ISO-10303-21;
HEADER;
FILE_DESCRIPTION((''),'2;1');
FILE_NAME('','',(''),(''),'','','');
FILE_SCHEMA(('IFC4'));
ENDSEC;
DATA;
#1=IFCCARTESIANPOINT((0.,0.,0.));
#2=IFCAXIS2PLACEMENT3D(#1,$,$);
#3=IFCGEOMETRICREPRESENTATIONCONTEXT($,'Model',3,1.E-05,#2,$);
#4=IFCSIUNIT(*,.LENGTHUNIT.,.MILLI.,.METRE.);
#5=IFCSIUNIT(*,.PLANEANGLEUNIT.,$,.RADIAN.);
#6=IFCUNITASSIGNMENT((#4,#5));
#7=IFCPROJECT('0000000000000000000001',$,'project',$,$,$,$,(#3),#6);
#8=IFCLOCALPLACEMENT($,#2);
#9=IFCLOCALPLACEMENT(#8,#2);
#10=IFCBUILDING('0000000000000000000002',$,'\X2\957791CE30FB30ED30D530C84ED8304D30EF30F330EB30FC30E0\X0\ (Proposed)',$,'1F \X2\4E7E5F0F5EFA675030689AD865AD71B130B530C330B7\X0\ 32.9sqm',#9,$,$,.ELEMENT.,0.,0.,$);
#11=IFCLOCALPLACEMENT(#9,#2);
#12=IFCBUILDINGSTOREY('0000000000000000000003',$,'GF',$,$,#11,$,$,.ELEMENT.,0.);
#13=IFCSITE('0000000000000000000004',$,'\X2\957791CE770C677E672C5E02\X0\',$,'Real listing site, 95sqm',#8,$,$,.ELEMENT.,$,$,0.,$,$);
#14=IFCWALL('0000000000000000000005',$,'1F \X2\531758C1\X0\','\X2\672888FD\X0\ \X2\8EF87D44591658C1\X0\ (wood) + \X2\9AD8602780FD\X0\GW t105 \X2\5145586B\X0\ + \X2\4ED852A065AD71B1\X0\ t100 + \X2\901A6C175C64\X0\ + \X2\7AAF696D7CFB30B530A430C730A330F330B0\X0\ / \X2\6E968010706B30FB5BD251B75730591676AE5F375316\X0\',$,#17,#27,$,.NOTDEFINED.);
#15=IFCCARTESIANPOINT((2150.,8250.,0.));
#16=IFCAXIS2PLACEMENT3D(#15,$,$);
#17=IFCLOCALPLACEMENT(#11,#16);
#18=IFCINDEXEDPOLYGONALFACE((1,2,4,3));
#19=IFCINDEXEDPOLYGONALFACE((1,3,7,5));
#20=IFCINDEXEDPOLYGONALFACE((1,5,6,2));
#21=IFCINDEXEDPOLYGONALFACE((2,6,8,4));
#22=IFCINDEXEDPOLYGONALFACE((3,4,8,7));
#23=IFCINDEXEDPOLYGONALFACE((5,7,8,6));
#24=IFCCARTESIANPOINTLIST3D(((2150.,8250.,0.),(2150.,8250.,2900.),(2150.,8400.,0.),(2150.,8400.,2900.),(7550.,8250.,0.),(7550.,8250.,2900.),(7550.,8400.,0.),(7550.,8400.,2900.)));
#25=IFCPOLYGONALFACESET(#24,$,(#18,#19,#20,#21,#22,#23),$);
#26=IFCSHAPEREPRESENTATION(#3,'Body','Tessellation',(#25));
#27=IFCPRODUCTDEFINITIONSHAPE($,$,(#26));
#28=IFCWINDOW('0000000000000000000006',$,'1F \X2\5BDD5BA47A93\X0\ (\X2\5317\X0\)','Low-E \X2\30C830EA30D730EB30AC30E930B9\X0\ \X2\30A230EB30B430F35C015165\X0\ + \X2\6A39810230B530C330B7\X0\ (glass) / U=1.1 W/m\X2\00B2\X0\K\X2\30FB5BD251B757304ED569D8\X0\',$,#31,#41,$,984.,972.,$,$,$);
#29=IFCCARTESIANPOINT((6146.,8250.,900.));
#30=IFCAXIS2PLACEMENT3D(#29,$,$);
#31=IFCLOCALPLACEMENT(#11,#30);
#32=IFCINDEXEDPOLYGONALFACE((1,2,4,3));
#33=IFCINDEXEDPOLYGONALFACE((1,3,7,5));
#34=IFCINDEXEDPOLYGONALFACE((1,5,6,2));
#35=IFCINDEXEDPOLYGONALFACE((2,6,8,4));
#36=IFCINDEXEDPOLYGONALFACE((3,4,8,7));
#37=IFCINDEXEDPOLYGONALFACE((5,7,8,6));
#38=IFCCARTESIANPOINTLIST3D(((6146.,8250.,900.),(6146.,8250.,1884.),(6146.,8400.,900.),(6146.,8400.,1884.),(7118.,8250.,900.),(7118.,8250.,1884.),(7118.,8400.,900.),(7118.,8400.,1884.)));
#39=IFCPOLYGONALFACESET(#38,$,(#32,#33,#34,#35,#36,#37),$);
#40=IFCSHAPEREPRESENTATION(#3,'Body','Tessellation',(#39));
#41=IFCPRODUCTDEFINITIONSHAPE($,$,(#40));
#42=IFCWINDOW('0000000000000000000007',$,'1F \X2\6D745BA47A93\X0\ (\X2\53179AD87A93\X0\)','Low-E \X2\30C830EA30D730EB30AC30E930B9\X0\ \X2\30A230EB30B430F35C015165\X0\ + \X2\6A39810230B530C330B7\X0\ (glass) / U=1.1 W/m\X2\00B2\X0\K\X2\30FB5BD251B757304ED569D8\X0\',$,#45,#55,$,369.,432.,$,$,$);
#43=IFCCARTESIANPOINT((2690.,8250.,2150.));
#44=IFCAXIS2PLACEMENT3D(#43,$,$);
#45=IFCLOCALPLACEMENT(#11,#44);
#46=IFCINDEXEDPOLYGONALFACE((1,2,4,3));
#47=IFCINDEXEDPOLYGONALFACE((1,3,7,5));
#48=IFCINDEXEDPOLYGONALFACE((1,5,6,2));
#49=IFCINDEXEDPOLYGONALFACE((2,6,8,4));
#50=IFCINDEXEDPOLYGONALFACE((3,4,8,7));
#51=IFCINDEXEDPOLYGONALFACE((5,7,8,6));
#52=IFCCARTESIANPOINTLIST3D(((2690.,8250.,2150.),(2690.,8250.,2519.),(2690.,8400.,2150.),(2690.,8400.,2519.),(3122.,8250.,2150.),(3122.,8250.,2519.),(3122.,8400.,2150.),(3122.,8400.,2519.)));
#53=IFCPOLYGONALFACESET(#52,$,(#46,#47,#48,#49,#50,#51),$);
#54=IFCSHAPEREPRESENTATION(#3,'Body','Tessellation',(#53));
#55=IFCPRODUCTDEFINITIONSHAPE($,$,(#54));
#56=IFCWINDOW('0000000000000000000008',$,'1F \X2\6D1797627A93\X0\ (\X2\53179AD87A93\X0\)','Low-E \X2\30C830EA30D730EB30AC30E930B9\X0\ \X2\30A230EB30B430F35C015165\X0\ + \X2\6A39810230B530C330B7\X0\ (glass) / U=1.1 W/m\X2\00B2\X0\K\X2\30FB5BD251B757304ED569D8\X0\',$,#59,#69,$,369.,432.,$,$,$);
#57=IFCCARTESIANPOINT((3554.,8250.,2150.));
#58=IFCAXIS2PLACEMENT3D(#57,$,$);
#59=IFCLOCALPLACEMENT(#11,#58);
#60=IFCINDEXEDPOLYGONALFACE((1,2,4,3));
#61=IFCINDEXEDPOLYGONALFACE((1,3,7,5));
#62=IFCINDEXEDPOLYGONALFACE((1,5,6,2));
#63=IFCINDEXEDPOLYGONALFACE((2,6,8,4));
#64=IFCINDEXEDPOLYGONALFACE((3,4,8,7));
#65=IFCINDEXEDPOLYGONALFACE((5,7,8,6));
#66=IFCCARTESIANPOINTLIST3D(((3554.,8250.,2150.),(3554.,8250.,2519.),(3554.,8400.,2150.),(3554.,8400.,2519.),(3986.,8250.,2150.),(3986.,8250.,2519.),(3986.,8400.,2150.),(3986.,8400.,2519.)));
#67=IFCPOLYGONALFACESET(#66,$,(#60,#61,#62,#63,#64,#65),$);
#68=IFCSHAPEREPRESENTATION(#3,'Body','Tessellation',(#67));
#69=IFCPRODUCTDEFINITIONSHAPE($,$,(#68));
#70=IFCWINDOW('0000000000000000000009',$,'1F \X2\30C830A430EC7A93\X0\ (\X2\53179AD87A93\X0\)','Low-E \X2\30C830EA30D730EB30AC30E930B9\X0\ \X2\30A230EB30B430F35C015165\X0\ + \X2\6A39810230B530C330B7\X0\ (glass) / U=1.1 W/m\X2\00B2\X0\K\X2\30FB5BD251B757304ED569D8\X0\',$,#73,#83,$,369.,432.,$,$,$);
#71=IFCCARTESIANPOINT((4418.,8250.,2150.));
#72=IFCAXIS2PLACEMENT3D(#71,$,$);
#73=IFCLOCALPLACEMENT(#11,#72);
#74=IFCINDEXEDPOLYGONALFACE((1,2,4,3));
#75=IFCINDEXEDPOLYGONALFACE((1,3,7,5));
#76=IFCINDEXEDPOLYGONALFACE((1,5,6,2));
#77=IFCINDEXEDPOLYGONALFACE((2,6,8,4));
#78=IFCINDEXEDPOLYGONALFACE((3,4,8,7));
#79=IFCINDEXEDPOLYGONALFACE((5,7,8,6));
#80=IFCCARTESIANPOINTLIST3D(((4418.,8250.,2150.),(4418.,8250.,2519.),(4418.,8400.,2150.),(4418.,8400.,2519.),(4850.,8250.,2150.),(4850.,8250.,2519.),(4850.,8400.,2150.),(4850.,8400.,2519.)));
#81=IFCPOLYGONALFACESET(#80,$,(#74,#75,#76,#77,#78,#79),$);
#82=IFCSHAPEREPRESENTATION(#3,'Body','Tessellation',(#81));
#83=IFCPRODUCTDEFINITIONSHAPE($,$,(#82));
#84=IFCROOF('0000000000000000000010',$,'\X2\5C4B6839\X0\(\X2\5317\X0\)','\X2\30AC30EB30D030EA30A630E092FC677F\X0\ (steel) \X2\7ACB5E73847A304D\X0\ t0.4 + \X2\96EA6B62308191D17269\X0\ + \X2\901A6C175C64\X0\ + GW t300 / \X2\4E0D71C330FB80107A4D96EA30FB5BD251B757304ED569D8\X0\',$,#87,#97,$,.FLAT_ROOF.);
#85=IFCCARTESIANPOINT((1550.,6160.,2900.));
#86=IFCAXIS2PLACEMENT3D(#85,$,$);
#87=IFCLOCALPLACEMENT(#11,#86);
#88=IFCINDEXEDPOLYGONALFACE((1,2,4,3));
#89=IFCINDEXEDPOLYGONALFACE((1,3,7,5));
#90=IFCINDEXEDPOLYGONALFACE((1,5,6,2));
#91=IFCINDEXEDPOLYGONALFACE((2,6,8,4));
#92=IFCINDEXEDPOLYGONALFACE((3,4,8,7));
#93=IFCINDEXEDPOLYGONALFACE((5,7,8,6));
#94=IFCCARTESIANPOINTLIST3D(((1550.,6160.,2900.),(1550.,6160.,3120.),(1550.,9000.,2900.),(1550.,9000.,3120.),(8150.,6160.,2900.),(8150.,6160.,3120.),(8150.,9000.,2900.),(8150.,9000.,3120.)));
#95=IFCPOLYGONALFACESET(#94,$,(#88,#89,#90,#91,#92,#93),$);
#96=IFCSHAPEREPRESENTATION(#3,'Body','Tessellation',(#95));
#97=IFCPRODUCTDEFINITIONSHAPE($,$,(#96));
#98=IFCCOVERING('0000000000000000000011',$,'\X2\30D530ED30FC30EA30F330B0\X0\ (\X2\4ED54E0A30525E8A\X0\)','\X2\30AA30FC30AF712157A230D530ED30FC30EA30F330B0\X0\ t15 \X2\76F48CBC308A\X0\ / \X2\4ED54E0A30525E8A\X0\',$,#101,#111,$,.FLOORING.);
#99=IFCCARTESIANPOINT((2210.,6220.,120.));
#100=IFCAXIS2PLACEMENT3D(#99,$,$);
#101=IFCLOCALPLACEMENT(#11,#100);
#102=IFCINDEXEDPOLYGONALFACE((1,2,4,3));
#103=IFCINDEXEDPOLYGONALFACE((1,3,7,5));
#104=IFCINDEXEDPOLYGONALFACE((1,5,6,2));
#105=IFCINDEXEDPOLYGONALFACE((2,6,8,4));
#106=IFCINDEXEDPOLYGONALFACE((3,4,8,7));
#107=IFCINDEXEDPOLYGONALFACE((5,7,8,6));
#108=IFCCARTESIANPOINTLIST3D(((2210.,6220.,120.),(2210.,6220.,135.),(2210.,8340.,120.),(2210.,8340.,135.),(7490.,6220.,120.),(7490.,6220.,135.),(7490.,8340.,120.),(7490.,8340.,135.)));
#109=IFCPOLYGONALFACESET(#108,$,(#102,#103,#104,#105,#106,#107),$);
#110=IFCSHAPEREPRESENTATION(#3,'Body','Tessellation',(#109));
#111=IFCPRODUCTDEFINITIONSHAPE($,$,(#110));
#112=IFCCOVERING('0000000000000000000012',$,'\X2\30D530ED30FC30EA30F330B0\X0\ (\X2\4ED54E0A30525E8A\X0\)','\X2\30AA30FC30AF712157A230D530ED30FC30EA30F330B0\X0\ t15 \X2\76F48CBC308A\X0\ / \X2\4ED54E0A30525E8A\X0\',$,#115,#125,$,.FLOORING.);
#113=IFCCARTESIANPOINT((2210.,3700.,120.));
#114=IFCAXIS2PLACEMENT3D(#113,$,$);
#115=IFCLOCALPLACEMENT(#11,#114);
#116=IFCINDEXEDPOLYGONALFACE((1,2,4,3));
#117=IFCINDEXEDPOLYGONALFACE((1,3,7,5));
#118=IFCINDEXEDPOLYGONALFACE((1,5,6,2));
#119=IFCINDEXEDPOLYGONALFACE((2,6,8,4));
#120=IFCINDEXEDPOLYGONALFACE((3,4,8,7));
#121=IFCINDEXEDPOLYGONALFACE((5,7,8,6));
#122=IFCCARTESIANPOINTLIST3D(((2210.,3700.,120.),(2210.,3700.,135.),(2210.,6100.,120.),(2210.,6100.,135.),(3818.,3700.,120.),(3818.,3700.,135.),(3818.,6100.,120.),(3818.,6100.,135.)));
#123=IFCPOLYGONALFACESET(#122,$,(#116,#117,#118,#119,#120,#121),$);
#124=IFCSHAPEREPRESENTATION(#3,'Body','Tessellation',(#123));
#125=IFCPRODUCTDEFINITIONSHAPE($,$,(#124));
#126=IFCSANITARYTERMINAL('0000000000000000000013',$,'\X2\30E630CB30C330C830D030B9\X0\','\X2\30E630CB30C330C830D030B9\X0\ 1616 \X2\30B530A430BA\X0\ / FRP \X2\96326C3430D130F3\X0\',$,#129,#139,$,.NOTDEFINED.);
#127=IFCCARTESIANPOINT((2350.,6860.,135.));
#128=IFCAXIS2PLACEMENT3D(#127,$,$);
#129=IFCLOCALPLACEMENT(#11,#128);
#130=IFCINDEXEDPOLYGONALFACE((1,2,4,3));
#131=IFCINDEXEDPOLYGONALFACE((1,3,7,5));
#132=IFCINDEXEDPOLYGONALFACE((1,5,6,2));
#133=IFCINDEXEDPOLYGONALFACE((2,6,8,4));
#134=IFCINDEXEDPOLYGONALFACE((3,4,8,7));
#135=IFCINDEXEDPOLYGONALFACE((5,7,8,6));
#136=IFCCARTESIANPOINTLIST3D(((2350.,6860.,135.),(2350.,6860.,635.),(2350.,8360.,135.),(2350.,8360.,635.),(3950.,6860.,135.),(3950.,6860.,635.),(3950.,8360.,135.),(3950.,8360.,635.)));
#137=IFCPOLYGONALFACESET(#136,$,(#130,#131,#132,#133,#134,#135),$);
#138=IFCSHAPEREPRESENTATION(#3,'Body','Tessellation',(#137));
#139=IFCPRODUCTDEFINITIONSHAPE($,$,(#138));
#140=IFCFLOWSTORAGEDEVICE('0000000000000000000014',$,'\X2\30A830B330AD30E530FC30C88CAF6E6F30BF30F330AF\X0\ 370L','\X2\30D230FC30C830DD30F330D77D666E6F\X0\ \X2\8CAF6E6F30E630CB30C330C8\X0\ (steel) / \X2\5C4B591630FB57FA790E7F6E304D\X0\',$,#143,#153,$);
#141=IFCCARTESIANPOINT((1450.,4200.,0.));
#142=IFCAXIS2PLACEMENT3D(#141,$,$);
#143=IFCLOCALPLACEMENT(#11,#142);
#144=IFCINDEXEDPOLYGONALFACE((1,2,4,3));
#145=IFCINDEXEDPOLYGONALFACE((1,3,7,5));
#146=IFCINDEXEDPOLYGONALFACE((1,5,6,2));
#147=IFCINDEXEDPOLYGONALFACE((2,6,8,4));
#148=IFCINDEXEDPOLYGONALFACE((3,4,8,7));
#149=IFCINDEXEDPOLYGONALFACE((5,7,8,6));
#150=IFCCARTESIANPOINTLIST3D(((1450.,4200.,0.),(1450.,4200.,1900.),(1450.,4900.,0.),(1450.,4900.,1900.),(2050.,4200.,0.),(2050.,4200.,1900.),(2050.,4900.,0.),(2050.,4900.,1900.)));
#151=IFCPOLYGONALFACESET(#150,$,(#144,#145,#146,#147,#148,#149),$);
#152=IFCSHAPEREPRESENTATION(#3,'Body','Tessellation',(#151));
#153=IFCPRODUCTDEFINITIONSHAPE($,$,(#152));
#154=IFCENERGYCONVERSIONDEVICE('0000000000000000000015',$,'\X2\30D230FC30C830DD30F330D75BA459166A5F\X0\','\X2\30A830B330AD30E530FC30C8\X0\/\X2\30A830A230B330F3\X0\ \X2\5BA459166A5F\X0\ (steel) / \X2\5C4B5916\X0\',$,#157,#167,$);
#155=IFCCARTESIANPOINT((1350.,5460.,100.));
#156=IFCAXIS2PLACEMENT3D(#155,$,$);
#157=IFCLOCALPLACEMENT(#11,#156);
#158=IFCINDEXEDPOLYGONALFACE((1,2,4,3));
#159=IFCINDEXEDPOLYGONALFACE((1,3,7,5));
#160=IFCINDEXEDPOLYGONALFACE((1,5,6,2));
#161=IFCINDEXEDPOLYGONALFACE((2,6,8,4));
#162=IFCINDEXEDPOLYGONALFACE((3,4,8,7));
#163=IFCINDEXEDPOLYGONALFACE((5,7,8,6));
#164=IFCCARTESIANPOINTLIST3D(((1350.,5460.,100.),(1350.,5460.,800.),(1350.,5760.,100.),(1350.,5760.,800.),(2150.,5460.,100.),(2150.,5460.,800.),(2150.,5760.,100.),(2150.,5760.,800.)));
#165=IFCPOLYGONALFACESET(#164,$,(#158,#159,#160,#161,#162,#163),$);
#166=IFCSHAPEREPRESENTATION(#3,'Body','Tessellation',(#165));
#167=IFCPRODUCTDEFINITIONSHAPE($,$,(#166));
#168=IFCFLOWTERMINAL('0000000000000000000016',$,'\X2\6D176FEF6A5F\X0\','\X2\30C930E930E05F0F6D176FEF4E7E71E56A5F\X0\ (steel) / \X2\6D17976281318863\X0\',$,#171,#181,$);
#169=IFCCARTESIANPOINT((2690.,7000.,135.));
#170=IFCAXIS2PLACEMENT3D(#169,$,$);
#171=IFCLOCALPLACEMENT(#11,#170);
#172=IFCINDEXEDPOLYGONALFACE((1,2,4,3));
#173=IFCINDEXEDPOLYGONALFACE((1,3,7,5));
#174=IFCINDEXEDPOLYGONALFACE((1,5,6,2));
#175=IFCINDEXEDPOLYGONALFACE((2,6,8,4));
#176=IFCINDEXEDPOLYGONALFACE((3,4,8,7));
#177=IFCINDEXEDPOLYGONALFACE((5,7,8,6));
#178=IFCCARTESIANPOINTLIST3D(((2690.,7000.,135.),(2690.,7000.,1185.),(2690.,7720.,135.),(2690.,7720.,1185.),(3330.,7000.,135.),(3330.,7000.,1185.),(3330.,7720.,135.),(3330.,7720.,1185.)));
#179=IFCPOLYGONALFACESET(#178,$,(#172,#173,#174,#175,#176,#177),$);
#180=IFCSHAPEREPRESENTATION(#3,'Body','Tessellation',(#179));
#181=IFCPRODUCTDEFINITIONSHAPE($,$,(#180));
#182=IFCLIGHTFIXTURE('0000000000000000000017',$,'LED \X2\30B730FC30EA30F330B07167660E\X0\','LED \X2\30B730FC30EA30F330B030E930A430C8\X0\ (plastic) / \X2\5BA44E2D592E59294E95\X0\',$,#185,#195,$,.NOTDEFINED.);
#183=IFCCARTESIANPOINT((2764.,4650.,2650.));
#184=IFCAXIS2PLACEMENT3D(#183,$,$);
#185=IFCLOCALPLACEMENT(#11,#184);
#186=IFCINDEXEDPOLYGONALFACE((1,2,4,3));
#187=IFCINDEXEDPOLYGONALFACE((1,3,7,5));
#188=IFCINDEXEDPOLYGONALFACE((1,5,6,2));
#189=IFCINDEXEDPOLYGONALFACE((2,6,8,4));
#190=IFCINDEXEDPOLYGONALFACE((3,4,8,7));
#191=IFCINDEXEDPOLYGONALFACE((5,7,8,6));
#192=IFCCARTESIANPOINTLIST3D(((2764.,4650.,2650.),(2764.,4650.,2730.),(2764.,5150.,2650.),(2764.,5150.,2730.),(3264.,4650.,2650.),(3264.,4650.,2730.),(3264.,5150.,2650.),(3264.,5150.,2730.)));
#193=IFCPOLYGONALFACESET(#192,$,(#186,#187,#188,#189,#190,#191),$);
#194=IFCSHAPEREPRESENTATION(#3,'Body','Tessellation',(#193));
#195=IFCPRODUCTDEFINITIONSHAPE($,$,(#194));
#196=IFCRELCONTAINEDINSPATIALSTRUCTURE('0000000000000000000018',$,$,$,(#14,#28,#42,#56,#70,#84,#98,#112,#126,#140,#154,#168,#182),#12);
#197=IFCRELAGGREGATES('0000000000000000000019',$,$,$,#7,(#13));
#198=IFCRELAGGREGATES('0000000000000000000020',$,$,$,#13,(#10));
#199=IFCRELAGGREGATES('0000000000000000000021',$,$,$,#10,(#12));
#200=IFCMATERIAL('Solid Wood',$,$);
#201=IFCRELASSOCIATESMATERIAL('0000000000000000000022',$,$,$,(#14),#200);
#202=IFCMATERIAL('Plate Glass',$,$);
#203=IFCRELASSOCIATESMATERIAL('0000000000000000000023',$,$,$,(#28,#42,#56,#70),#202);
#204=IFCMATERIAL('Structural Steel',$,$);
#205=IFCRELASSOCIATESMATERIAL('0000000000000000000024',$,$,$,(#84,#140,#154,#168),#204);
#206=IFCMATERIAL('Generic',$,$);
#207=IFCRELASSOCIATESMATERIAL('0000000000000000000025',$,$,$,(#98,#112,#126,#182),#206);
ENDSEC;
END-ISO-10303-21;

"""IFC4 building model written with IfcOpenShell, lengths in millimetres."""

from ifc_helpers import new_model, si_unit, frame, frame_2d, origin, place, context, project, spatial, rectangle, extrude, material, element, fill, save


model = new_model("IFC4")

# Units and contexts
model_context = context("Model", 3, precision=1e-05, world=origin())
ifc_project = project(units=[si_unit("LENGTHUNIT", "METRE", prefix="MILLI"), si_unit("PLANEANGLEUNIT", "RADIAN")], contexts=[model_context])

# Site, building, storey
site_placement = place(None, origin())
site = spatial("IfcSite", under=ifc_project, at=site_placement, Name="長野県松本市", ObjectType="Real listing site, 95sqm", CompositionType="ELEMENT", RefElevation=0.0)
building_placement = place(site_placement, origin())
building = spatial("IfcBuilding", under=site, at=building_placement, Name="長野・ロフト付きワンルーム (Proposed)", ObjectType="1F 乾式建材と高断熱サッシ 32.9sqm", CompositionType="ELEMENT", ElevationOfRefHeight=0.0, ElevationOfTerrain=0.0)
storey_placement = place(building_placement, origin())
storey = spatial("IfcBuildingStorey", under=building, at=storey_placement, Name="GF", CompositionType="ELEMENT", Elevation=0.0)

# Shared definitions
ifc_material_1 = material(Name="Solid Wood")

# Wall, openings, windows
wall_1_placement = place(storey_placement, frame((2150.0, 8250.0, 0.0)))
wall_1 = element("IfcWall", 1, at=wall_1_placement, inside=storey, material=ifc_material_1, Name="1F 北壁", Description="木製 軸組外壁 (wood) + 高性能GW t105 充填 + 付加断熱 t100 + 通気層 + 窯業系サイディング / 準耐火・寒冷地外皮強化", PredefinedType="NOTDEFINED", context=model_context, shape_type="SweptSolid", body=[
    extrude(rectangle(XDim=5400.0, YDim=150.0, at=frame_2d((2700.0, 75.0))), frame((2150.0, 8250.0, 0.0)), (0.0, 0.0, 1.0), 2900.0),
])
opening_1_placement = place(storey_placement, frame((6146.0, 8250.0, 900.0)))
opening_1 = element("IfcOpeningElement", 2, at=opening_1_placement, cuts=wall_1, PredefinedType="NOTDEFINED", context=model_context, shape_type="SweptSolid", body=[
    extrude(rectangle(XDim=972.0, YDim=150.0, at=frame_2d((486.0, 75.0))), frame((6146.0, 8250.0, 900.0)), (0.0, 0.0, 1.0), 984.0),
])
opening_2_placement = place(storey_placement, frame((2690.0, 8250.0, 2150.0)))
opening_2 = element("IfcOpeningElement", 3, at=opening_2_placement, cuts=wall_1, PredefinedType="NOTDEFINED", context=model_context, shape_type="SweptSolid", body=[
    extrude(rectangle(XDim=432.0, YDim=150.0, at=frame_2d((216.0, 75.0))), frame((2690.0, 8250.0, 2150.0)), (0.0, 0.0, 1.0), 369.0),
])
opening_3_placement = place(storey_placement, frame((3554.0, 8250.0, 2150.0)))
opening_3 = element("IfcOpeningElement", 4, at=opening_3_placement, cuts=wall_1, PredefinedType="NOTDEFINED", context=model_context, shape_type="SweptSolid", body=[
    extrude(rectangle(XDim=432.0, YDim=150.0, at=frame_2d((216.0, 75.0))), frame((3554.0, 8250.0, 2150.0)), (0.0, 0.0, 1.0), 369.0),
])
opening_4_placement = place(storey_placement, frame((4418.0, 8250.0, 2150.0)))
opening_4 = element("IfcOpeningElement", 5, at=opening_4_placement, cuts=wall_1, PredefinedType="NOTDEFINED", context=model_context, shape_type="SweptSolid", body=[
    extrude(rectangle(XDim=432.0, YDim=150.0, at=frame_2d((216.0, 75.0))), frame((4418.0, 8250.0, 2150.0)), (0.0, 0.0, 1.0), 369.0),
])
ifc_material_2 = material(Name="Plate Glass")
window_1_placement = place(storey_placement, frame((6146.0, 8250.0, 900.0)))
window_1 = element("IfcWindow", 6, at=window_1_placement, inside=storey, material=ifc_material_2, Name="1F 寝室窓 (北)", Description="Low-E トリプルガラス アルゴン封入 + 樹脂サッシ (glass) / U=1.1 W/m²K・寒冷地仕様", OverallHeight=984.0, OverallWidth=972.0, context=model_context, shape_type="SweptSolid", body=[
    extrude(rectangle(XDim=972.0, YDim=150.0, at=frame_2d((486.0, 75.0))), frame((6146.0, 8250.0, 900.0)), (0.0, 0.0, 1.0), 984.0),
])
fill(opening_1, window_1)
window_2_placement = place(storey_placement, frame((2690.0, 8250.0, 2150.0)))
window_2 = element("IfcWindow", 7, at=window_2_placement, inside=storey, material=ifc_material_2, Name="1F 浴室窓 (北高窓)", Description="Low-E トリプルガラス アルゴン封入 + 樹脂サッシ (glass) / U=1.1 W/m²K・寒冷地仕様", OverallHeight=369.0, OverallWidth=432.0, context=model_context, shape_type="SweptSolid", body=[
    extrude(rectangle(XDim=432.0, YDim=150.0, at=frame_2d((216.0, 75.0))), frame((2690.0, 8250.0, 2150.0)), (0.0, 0.0, 1.0), 369.0),
])
fill(opening_2, window_2)
window_3_placement = place(storey_placement, frame((3554.0, 8250.0, 2150.0)))
window_3 = element("IfcWindow", 8, at=window_3_placement, inside=storey, material=ifc_material_2, Name="1F 洗面窓 (北高窓)", Description="Low-E トリプルガラス アルゴン封入 + 樹脂サッシ (glass) / U=1.1 W/m²K・寒冷地仕様", OverallHeight=369.0, OverallWidth=432.0, context=model_context, shape_type="SweptSolid", body=[
    extrude(rectangle(XDim=432.0, YDim=150.0, at=frame_2d((216.0, 75.0))), frame((3554.0, 8250.0, 2150.0)), (0.0, 0.0, 1.0), 369.0),
])
fill(opening_3, window_3)
window_4_placement = place(storey_placement, frame((4418.0, 8250.0, 2150.0)))
window_4 = element("IfcWindow", 9, at=window_4_placement, inside=storey, material=ifc_material_2, Name="1F トイレ窓 (北高窓)", Description="Low-E トリプルガラス アルゴン封入 + 樹脂サッシ (glass) / U=1.1 W/m²K・寒冷地仕様", OverallHeight=369.0, OverallWidth=432.0, context=model_context, shape_type="SweptSolid", body=[
    extrude(rectangle(XDim=432.0, YDim=150.0, at=frame_2d((216.0, 75.0))), frame((4418.0, 8250.0, 2150.0)), (0.0, 0.0, 1.0), 369.0),
])
fill(opening_4, window_4)

# Roof
ifc_material_3 = material(Name="Structural Steel")
roof_placement = place(storey_placement, frame((1550.0, 6160.0, 2900.0)))
element("IfcRoof", 10, at=roof_placement, inside=storey, material=ifc_material_3, Name="屋根(北)", Description="ガルバリウム鋼板 (steel) 立平葺き t0.4 + 雪止め金物 + 通気層 + GW t300 / 不燃・耐積雪・寒冷地仕様", PredefinedType="FLAT_ROOF", context=model_context, shape_type="SweptSolid", body=[
    extrude(rectangle(XDim=6600.0, YDim=2840.0, at=frame_2d((3300.0, 1420.0))), frame((1550.0, 6160.0, 2900.0)), (0.0, 0.0, 1.0), 220.0),
])

# Coverings
ifc_material_4 = material(Name="Generic")
covering_1_placement = place(storey_placement, frame((2210.0, 6220.0, 120.0)))
element("IfcCovering", 11, at=covering_1_placement, inside=storey, material=ifc_material_4, Name="フローリング (仕上げ床)", Description="オーク無垢フローリング t15 直貼り / 仕上げ床", PredefinedType="FLOORING", context=model_context, shape_type="SweptSolid", body=[
    extrude(rectangle(XDim=5280.0, YDim=2120.0, at=frame_2d((2640.0, 1060.0))), frame((2210.0, 6220.0, 120.0)), (0.0, 0.0, 1.0), 15.0),
])
covering_2_placement = place(storey_placement, frame((2210.0, 3700.0, 120.0)))
element("IfcCovering", 12, at=covering_2_placement, inside=storey, material=ifc_material_4, Name="フローリング (仕上げ床)", Description="オーク無垢フローリング t15 直貼り / 仕上げ床", PredefinedType="FLOORING", context=model_context, shape_type="SweptSolid", body=[
    extrude(rectangle(XDim=1608.0, YDim=2400.0, at=frame_2d((804.0, 1200.0))), frame((2210.0, 3700.0, 120.0)), (0.0, 0.0, 1.0), 15.0),
])

# Sanitary terminal
sanitary_terminal_placement = place(storey_placement, frame((2350.0, 6860.0, 135.0)))
element("IfcSanitaryTerminal", 13, at=sanitary_terminal_placement, inside=storey, material=ifc_material_4, Name="ユニットバス", Description="ユニットバス 1616 サイズ / FRP 防水パン", PredefinedType="NOTDEFINED", context=model_context, shape_type="SweptSolid", body=[
    extrude(rectangle(XDim=1600.0, YDim=1500.0, at=frame_2d((800.0, 750.0))), frame((2350.0, 6860.0, 135.0)), (0.0, 0.0, 1.0), 500.0),
])

# Flow storage device
flow_storage_device_placement = place(storey_placement, frame((1450.0, 4200.0, 0.0)))
element("IfcFlowStorageDevice", 14, at=flow_storage_device_placement, inside=storey, material=ifc_material_3, Name="エコキュート貯湯タンク 370L", Description="ヒートポンプ給湯 貯湯ユニット (steel) / 屋外・基礎置き", context=model_context, shape_type="SweptSolid", body=[
    extrude(rectangle(XDim=600.0, YDim=700.0, at=frame_2d((300.0, 350.0))), frame((1450.0, 4200.0, 0.0)), (0.0, 0.0, 1.0), 1900.0),
])

# Energy conversion device
energy_conversion_device_placement = place(storey_placement, frame((1350.0, 5460.0, 100.0)))
element("IfcEnergyConversionDevice", 15, at=energy_conversion_device_placement, inside=storey, material=ifc_material_3, Name="ヒートポンプ室外機", Description="エコキュート/エアコン 室外機 (steel) / 屋外", context=model_context, shape_type="SweptSolid", body=[
    extrude(rectangle(XDim=800.0, YDim=300.0, at=frame_2d((400.0, 150.0))), frame((1350.0, 5460.0, 100.0)), (0.0, 0.0, 1.0), 700.0),
])

# Flow terminal
flow_terminal_placement = place(storey_placement, frame((2690.0, 7000.0, 135.0)))
element("IfcFlowTerminal", 16, at=flow_terminal_placement, inside=storey, material=ifc_material_3, Name="洗濯機", Description="ドラム式洗濯乾燥機 (steel) / 洗面脱衣", context=model_context, shape_type="SweptSolid", body=[
    extrude(rectangle(XDim=640.0, YDim=720.0, at=frame_2d((320.0, 360.0))), frame((2690.0, 7000.0, 135.0)), (0.0, 0.0, 1.0), 1050.0),
])

# Light fixture
light_fixture_placement = place(storey_placement, frame((2764.0, 4650.0, 2650.0)))
element("IfcLightFixture", 17, at=light_fixture_placement, inside=storey, material=ifc_material_4, Name="LED シーリング照明", Description="LED シーリングライト (plastic) / 室中央天井", PredefinedType="NOTDEFINED", context=model_context, shape_type="SweptSolid", body=[
    extrude(rectangle(XDim=500.0, YDim=500.0, at=frame_2d((250.0, 250.0))), frame((2764.0, 4650.0, 2650.0)), (0.0, 0.0, 1.0), 80.0),
])

save(model, "model.ifc")
